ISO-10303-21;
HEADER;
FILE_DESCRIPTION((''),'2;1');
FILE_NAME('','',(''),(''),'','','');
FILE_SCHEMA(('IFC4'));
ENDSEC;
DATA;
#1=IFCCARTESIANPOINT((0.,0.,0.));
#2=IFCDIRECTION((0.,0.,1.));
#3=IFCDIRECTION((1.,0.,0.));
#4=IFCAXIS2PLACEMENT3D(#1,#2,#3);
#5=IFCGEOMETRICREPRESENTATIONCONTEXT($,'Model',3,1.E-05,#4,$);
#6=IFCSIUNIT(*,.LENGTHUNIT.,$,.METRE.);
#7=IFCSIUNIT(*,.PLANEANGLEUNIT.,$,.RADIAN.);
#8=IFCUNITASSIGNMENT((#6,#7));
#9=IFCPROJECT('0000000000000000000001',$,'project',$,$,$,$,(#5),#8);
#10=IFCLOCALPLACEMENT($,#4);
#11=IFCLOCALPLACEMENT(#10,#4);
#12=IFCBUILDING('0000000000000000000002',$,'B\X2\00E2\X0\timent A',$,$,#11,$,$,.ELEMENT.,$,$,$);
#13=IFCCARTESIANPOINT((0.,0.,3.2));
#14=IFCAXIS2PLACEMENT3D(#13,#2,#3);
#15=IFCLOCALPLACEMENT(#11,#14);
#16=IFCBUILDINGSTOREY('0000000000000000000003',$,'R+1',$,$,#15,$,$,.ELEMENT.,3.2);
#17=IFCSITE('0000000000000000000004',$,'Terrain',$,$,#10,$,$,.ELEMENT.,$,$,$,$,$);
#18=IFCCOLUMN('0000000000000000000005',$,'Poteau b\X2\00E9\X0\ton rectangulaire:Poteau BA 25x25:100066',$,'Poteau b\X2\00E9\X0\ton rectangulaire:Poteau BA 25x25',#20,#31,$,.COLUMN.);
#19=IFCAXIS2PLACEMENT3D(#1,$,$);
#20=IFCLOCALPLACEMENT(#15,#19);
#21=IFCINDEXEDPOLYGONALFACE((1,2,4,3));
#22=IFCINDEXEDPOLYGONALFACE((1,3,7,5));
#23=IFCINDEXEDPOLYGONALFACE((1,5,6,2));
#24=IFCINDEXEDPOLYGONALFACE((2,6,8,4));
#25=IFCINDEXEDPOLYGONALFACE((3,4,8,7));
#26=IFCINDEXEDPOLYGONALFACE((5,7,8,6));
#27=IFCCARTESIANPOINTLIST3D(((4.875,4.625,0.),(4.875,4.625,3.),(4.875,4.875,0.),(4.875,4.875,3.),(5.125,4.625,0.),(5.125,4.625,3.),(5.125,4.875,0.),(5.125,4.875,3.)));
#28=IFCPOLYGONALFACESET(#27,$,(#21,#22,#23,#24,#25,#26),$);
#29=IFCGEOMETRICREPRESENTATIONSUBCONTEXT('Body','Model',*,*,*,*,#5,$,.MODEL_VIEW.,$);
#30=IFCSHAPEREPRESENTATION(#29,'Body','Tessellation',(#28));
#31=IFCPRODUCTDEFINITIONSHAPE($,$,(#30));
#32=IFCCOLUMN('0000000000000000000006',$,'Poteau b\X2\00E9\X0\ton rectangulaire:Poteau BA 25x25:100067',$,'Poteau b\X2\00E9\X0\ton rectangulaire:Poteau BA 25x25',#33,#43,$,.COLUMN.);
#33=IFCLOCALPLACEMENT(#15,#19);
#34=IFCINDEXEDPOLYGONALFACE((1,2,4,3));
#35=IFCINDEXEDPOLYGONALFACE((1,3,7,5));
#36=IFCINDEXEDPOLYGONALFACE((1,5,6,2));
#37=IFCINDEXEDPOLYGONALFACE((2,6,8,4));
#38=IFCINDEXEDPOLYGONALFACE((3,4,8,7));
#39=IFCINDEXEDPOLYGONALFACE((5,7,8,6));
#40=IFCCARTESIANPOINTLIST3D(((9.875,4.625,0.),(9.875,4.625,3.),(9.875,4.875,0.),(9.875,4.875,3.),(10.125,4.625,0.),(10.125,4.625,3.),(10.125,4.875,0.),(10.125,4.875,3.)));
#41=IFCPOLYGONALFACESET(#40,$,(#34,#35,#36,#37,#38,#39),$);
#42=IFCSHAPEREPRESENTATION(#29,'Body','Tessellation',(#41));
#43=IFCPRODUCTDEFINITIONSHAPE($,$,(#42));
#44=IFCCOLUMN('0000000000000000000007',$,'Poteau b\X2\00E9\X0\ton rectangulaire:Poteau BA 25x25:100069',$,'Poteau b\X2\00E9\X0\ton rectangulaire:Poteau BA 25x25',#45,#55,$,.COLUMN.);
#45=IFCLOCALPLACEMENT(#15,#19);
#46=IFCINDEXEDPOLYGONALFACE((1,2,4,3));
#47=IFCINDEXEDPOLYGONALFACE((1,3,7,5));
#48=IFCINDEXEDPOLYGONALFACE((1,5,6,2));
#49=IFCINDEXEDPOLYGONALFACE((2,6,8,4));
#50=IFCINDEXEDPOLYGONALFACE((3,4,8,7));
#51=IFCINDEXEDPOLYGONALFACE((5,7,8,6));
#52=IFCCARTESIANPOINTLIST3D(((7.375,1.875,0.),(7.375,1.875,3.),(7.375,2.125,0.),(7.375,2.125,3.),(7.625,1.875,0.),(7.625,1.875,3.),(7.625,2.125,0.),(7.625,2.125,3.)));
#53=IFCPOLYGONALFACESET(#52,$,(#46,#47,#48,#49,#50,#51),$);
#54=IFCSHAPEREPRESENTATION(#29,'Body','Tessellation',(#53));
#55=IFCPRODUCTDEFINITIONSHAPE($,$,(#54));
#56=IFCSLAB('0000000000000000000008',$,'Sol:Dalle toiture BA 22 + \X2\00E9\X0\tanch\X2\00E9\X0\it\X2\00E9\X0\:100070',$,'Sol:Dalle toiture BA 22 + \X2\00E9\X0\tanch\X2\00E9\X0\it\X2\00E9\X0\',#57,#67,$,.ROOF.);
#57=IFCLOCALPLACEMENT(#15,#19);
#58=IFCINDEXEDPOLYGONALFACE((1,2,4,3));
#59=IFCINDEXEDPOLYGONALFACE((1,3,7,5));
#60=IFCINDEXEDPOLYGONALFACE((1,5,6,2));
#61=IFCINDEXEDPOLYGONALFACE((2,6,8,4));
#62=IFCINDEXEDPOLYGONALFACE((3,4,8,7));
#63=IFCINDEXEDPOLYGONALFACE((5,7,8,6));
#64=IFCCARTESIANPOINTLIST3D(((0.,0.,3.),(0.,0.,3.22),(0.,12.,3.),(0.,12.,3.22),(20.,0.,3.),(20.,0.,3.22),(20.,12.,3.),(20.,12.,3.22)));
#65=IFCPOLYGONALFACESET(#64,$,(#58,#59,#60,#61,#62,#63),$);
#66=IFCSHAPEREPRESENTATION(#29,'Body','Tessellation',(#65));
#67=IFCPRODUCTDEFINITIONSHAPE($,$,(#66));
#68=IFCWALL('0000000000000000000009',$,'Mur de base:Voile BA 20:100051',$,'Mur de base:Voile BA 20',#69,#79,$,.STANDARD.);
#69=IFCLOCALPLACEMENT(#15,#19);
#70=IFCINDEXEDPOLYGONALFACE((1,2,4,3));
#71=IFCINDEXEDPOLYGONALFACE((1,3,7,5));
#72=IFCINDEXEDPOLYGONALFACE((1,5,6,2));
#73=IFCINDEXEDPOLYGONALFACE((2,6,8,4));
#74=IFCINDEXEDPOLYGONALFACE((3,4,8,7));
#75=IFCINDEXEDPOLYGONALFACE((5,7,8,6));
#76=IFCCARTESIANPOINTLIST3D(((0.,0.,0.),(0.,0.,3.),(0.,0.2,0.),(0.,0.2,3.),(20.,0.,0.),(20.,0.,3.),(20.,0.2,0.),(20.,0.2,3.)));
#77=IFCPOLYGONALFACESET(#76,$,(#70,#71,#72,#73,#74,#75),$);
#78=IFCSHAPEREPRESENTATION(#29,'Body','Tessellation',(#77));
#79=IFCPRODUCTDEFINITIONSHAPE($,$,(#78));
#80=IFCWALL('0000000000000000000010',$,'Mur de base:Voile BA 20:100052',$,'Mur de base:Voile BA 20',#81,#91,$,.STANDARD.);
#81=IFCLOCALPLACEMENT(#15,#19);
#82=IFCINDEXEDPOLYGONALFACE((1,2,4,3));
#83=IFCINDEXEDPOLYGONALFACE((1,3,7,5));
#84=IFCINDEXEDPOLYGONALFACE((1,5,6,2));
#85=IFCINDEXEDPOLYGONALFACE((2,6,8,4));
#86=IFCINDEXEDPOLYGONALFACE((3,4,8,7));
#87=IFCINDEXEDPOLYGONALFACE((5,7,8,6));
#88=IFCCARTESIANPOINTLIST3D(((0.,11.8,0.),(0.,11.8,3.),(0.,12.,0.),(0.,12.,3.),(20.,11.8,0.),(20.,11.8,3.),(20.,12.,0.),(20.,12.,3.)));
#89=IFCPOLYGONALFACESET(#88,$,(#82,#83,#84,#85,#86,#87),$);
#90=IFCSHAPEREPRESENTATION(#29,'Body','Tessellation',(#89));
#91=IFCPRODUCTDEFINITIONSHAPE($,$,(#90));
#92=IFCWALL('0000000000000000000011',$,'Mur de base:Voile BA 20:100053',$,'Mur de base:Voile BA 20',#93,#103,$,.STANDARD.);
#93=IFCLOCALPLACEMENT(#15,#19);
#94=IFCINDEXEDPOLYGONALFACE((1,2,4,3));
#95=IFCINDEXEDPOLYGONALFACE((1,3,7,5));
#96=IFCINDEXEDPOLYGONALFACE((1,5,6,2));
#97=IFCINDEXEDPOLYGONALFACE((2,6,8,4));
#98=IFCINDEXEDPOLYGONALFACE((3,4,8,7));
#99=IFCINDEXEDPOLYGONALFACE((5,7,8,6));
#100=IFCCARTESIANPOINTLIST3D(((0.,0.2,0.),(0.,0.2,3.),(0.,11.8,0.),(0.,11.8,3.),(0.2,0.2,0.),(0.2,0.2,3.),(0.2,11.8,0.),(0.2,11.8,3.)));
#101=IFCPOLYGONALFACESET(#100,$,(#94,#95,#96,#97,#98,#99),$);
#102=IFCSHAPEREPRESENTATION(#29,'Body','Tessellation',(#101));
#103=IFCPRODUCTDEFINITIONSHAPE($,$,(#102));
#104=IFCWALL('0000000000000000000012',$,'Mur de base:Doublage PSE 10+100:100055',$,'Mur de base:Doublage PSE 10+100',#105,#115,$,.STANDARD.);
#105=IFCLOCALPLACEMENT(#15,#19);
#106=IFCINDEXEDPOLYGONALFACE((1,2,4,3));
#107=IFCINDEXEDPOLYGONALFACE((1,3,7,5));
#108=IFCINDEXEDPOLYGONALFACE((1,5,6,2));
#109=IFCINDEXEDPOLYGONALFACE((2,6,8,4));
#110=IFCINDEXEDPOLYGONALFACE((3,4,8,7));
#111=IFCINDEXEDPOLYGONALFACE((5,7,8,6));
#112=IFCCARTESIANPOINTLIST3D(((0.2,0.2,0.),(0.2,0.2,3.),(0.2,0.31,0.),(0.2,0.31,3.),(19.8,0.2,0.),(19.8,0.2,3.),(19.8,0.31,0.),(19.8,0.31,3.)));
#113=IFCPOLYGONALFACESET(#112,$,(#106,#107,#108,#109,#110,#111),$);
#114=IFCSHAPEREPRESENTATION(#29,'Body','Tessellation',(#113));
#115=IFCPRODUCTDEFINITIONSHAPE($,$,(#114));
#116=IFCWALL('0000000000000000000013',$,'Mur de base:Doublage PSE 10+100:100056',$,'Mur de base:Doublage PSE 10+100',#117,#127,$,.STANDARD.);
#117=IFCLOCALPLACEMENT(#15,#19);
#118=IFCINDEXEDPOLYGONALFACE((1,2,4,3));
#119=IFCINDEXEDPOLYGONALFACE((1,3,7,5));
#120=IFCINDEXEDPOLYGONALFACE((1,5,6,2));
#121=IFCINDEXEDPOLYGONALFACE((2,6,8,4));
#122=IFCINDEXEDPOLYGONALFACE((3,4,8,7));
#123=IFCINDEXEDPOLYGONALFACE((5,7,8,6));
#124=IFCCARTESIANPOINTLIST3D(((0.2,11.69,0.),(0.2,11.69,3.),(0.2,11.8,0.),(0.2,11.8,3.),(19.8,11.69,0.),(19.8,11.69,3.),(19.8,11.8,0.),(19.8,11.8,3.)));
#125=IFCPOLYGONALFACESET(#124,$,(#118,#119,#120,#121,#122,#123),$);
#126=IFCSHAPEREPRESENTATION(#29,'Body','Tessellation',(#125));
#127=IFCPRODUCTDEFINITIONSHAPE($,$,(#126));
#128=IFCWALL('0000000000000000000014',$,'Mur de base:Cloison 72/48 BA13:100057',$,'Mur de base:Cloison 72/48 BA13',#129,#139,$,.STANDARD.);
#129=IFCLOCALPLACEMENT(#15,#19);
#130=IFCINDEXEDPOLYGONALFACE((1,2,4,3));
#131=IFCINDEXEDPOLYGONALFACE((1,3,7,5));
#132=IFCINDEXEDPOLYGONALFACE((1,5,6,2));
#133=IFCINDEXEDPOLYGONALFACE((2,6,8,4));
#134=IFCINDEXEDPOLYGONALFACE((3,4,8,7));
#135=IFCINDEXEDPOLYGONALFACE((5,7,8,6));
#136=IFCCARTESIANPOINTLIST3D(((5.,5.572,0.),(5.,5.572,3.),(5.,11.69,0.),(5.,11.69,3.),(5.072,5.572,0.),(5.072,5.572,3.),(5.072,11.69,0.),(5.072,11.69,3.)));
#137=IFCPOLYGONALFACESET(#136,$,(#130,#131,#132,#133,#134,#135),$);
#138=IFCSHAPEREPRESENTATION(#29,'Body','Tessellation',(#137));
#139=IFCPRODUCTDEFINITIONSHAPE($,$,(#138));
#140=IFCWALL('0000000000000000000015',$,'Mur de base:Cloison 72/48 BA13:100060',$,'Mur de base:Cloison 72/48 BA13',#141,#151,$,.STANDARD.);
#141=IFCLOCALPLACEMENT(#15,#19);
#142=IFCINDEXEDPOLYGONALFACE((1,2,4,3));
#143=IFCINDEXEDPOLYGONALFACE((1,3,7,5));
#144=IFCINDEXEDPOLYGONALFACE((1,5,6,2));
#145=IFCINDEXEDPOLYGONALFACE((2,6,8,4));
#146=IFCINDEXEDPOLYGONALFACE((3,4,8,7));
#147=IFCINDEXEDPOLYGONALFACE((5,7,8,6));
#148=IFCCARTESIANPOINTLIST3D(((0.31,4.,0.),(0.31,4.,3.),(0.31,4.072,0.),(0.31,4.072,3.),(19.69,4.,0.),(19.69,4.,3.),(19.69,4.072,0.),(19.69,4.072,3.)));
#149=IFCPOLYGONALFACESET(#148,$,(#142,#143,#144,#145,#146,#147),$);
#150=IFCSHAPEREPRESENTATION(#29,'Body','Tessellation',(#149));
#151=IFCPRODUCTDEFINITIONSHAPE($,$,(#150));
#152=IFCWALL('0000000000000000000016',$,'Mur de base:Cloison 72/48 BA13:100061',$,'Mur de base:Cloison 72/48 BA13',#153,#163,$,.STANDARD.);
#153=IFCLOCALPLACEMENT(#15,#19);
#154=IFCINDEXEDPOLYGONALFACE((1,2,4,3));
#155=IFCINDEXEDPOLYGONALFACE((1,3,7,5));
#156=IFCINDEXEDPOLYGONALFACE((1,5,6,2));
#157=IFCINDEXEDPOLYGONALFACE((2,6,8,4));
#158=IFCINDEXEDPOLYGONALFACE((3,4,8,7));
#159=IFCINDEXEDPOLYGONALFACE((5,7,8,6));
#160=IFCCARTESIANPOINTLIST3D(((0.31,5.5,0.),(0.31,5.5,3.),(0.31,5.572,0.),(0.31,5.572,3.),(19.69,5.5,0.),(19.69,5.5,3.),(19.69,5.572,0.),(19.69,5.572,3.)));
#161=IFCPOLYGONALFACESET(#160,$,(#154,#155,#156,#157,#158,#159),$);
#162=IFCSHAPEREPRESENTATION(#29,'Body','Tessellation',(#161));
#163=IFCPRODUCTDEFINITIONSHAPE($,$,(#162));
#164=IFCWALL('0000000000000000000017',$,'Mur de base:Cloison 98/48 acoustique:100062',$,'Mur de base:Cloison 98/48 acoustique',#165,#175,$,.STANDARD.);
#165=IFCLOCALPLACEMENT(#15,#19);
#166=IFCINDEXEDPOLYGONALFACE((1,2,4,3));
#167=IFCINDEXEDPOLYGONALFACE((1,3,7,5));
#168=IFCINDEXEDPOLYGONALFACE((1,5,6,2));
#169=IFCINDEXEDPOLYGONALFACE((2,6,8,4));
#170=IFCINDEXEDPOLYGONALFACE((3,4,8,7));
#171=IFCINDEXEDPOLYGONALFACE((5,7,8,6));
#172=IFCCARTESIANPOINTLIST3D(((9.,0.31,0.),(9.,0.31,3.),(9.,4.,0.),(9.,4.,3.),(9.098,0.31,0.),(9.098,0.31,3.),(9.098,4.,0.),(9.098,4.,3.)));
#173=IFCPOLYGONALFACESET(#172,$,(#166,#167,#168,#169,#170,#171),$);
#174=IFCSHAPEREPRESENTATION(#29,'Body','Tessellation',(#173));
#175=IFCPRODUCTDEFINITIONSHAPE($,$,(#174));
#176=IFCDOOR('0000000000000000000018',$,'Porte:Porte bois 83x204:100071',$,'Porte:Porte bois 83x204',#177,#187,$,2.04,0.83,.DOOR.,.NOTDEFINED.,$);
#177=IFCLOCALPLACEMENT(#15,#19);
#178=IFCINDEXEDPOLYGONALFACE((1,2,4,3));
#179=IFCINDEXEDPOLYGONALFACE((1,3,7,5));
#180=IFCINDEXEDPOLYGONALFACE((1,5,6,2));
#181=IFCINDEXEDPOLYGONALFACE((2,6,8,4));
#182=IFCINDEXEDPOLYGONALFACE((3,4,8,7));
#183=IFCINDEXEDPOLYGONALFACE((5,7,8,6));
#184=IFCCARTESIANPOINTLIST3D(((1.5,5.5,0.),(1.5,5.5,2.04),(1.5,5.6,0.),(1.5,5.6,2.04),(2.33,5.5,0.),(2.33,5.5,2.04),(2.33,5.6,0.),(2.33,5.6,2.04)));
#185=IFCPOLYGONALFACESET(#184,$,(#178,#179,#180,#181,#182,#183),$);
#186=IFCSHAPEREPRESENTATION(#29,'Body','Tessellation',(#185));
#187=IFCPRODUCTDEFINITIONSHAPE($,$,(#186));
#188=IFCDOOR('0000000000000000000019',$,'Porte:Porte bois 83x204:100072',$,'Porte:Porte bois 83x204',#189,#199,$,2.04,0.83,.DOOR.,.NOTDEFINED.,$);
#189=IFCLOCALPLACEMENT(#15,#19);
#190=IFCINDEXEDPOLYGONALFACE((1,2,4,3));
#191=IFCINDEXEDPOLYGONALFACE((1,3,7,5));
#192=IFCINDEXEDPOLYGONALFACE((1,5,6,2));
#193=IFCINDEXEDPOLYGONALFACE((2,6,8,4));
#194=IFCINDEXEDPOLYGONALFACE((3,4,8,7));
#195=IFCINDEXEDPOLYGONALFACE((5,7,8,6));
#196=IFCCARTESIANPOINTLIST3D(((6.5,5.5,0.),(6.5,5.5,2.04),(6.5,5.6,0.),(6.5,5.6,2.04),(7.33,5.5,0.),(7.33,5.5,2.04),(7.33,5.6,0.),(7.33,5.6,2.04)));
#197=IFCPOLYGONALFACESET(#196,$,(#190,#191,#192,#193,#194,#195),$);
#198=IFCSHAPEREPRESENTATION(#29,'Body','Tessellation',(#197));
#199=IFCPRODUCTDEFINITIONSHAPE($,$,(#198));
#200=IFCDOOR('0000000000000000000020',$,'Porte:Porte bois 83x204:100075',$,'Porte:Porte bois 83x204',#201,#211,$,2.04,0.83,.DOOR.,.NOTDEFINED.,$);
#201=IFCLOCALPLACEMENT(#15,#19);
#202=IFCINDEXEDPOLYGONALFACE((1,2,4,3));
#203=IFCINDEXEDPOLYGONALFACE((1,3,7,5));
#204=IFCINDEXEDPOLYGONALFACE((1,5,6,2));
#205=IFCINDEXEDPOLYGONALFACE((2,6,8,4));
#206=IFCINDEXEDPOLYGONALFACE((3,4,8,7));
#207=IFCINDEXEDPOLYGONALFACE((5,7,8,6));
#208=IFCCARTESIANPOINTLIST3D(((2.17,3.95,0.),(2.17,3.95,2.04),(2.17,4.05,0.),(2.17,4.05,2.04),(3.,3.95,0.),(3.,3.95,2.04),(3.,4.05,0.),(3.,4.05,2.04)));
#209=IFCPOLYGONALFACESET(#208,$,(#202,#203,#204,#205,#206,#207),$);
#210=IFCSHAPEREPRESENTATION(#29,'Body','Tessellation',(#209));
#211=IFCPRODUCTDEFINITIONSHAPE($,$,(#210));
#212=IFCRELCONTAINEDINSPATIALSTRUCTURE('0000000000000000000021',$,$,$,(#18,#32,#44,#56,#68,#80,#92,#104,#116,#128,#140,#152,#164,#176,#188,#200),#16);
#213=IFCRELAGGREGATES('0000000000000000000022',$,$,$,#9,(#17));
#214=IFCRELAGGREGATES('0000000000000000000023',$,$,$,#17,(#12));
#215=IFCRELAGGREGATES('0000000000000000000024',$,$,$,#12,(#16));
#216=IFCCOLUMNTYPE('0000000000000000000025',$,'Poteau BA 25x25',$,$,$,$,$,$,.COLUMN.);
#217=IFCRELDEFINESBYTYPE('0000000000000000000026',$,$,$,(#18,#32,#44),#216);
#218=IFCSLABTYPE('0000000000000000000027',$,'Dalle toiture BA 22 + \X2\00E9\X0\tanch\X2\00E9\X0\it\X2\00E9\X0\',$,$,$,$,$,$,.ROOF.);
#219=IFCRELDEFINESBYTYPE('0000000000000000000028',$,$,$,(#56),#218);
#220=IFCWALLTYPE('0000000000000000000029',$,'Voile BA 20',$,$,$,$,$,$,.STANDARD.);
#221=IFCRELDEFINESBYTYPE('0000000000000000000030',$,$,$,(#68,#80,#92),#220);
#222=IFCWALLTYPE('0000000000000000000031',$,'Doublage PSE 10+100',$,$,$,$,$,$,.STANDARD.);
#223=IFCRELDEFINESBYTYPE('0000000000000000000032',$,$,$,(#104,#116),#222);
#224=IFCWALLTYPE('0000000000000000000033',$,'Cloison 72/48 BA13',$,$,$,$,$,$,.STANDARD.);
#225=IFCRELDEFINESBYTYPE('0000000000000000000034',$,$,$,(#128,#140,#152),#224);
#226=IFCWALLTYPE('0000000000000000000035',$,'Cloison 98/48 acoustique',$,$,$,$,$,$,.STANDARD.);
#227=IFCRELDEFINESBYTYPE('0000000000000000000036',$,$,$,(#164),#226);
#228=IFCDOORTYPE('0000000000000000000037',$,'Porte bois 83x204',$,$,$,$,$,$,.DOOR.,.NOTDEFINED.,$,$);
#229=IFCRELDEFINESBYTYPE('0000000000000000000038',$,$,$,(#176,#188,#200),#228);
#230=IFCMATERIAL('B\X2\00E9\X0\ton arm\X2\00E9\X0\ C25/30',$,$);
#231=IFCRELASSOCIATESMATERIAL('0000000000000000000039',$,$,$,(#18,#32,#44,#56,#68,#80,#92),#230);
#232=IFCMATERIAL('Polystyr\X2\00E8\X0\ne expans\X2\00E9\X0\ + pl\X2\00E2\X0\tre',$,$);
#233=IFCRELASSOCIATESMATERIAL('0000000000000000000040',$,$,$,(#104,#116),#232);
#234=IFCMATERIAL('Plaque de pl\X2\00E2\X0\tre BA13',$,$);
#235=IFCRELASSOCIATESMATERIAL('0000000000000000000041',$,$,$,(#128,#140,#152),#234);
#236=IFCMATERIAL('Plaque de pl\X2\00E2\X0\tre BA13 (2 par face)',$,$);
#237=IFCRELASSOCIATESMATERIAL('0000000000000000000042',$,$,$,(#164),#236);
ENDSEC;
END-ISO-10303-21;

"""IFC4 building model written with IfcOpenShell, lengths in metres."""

from ifc_helpers import new_model, si_unit, frame, frame_2d, origin_with_axes, place, context, subcontext, project, spatial, rectangle, extrude, material, type_object, element, save


model = new_model("IFC4")

# Units and contexts
model_context = context("Model", 3, precision=1e-05, world=origin_with_axes())
body_context = subcontext(model_context, "Body", "Model", "MODEL_VIEW")
ifc_project = project(units=[si_unit("LENGTHUNIT", "METRE"), si_unit("PLANEANGLEUNIT", "RADIAN")], contexts=[model_context])

# Site, building, storey
site_placement = place(None, origin_with_axes())
site = spatial("IfcSite", under=ifc_project, at=site_placement, Name="Terrain", CompositionType="ELEMENT")
building_placement = place(site_placement, origin_with_axes())
building = spatial("IfcBuilding", under=site, at=building_placement, Name="Bâtiment A", CompositionType="ELEMENT")
storey_placement = place(building_placement, frame((0.0, 0.0, 3.2), z_axis=(0.0, 0.0, 1.0), x_axis=(1.0, 0.0, 0.0)))
storey = spatial("IfcBuildingStorey", under=building, at=storey_placement, Name="R+1", CompositionType="ELEMENT", Elevation=3.2)

# Columns
ifc_material_1 = material(Name="Béton armé C25/30")
column_type = type_object("IfcColumnType", Name="Poteau BA 25x25", PredefinedType="COLUMN")
for number, where, z_axis, x_axis, name in (
    (1, (4.875, 4.625, 0.0), (0.0, 0.0, 1.0), (1.0, 0.0, 0.0), "Poteau béton rectangulaire:Poteau BA 25x25:100066"),
    (2, (9.875, 4.625, 0.0), (0.0, 0.0, 1.0), (1.0, 0.0, 0.0), "Poteau béton rectangulaire:Poteau BA 25x25:100067"),
    (3, (7.375, 1.875, 0.0), (0.0, 0.0, 1.0), (1.0, 0.0, 0.0), "Poteau béton rectangulaire:Poteau BA 25x25:100069"),
):
    element("IfcColumn", number, at=place(storey_placement, frame(where, z_axis=z_axis, x_axis=x_axis)), inside=storey, type_object=column_type, material=ifc_material_1, Name=name, ObjectType="Poteau béton rectangulaire:Poteau BA 25x25", PredefinedType="COLUMN", context=body_context, shape_type="SweptSolid", body=[
        extrude(rectangle(XDim=0.25, YDim=0.25, at=frame_2d((0.125, 0.125))), origin_with_axes(), (0.0, 0.0, 1.0), 3.0),
    ])

# Slab
slab_type = type_object("IfcSlabType", Name="Dalle toiture BA 22 + étanchéité", PredefinedType="ROOF")
slab_placement = place(storey_placement, frame((0.0, 0.0, 3.0), z_axis=(0.0, 0.0, 1.0), x_axis=(1.0, 0.0, 0.0)))
element("IfcSlab", 4, at=slab_placement, inside=storey, type_object=slab_type, material=ifc_material_1, Name="Sol:Dalle toiture BA 22 + étanchéité:100070", ObjectType="Sol:Dalle toiture BA 22 + étanchéité", PredefinedType="ROOF", context=body_context, shape_type="SweptSolid", body=[
    extrude(rectangle(XDim=20.0, YDim=12.0, at=frame_2d((10.0, 6.0))), origin_with_axes(), (0.0, 0.0, 1.0), 0.22),
])

# Walls
wall_type_1 = type_object("IfcWallType", Name="Voile BA 20", PredefinedType="STANDARD")
for number, where, z_axis, x_axis, name in (
    (5, (0.0, 0.0, 0.0), (0.0, 0.0, 1.0), (1.0, 0.0, 0.0), "Mur de base:Voile BA 20:100051"),
    (6, (0.0, 11.8, 0.0), (0.0, 0.0, 1.0), (1.0, 0.0, 0.0), "Mur de base:Voile BA 20:100052"),
):
    element("IfcWall", number, at=place(storey_placement, frame(where, z_axis=z_axis, x_axis=x_axis)), inside=storey, type_object=wall_type_1, material=ifc_material_1, Name=name, ObjectType="Mur de base:Voile BA 20", PredefinedType="STANDARD", context=body_context, shape_type="SweptSolid", body=[
        extrude(rectangle(XDim=20.0, YDim=0.2, at=frame_2d((10.0, 0.1))), origin_with_axes(), (0.0, 0.0, 1.0), 3.0),
    ])
wall_1_placement = place(storey_placement, frame((0.2, 0.2, 0.0), z_axis=(0.0, 0.0, 1.0), x_axis=(0.0, 1.0, 0.0)))
element("IfcWall", 7, at=wall_1_placement, inside=storey, type_object=wall_type_1, material=ifc_material_1, Name="Mur de base:Voile BA 20:100053", ObjectType="Mur de base:Voile BA 20", PredefinedType="STANDARD", context=body_context, shape_type="SweptSolid", body=[
    extrude(rectangle(XDim=11.6, YDim=0.2, at=frame_2d((5.8, 0.1))), origin_with_axes(), (0.0, 0.0, 1.0), 3.0),
])
ifc_material_2 = material(Name="Polystyrène expansé + plâtre")
wall_type_2 = type_object("IfcWallType", Name="Doublage PSE 10+100", PredefinedType="STANDARD")
for number, where, z_axis, x_axis, name in (
    (8, (0.2, 0.2, 0.0), (0.0, 0.0, 1.0), (1.0, 0.0, 0.0), "Mur de base:Doublage PSE 10+100:100055"),
    (9, (0.2, 11.69, 0.0), (0.0, 0.0, 1.0), (1.0, 0.0, 0.0), "Mur de base:Doublage PSE 10+100:100056"),
):
    element("IfcWall", number, at=place(storey_placement, frame(where, z_axis=z_axis, x_axis=x_axis)), inside=storey, type_object=wall_type_2, material=ifc_material_2, Name=name, ObjectType="Mur de base:Doublage PSE 10+100", PredefinedType="STANDARD", context=body_context, shape_type="SweptSolid", body=[
        extrude(rectangle(XDim=19.6, YDim=0.11, at=frame_2d((9.8, 0.055))), origin_with_axes(), (0.0, 0.0, 1.0), 3.0),
    ])
ifc_material_3 = material(Name="Plaque de plâtre BA13")
wall_type_3 = type_object("IfcWallType", Name="Cloison 72/48 BA13", PredefinedType="STANDARD")
wall_2_placement = place(storey_placement, frame((5.072, 5.572, 0.0), z_axis=(0.0, 0.0, 1.0), x_axis=(0.0, 1.0, 0.0)))
element("IfcWall", 10, at=wall_2_placement, inside=storey, type_object=wall_type_3, material=ifc_material_3, Name="Mur de base:Cloison 72/48 BA13:100057", ObjectType="Mur de base:Cloison 72/48 BA13", PredefinedType="STANDARD", context=body_context, shape_type="SweptSolid", body=[
    extrude(rectangle(XDim=6.118, YDim=0.072, at=frame_2d((3.059, 0.036))), origin_with_axes(), (0.0, 0.0, 1.0), 3.0),
])
for number, where, z_axis, x_axis, name in (
    (11, (0.31, 4.0, 0.0), (0.0, 0.0, 1.0), (1.0, 0.0, 0.0), "Mur de base:Cloison 72/48 BA13:100060"),
    (12, (0.31, 5.5, 0.0), (0.0, 0.0, 1.0), (1.0, 0.0, 0.0), "Mur de base:Cloison 72/48 BA13:100061"),
):
    element("IfcWall", number, at=place(storey_placement, frame(where, z_axis=z_axis, x_axis=x_axis)), inside=storey, type_object=wall_type_3, material=ifc_material_3, Name=name, ObjectType="Mur de base:Cloison 72/48 BA13", PredefinedType="STANDARD", context=body_context, shape_type="SweptSolid", body=[
        extrude(rectangle(XDim=19.38, YDim=0.072, at=frame_2d((9.69, 0.036))), origin_with_axes(), (0.0, 0.0, 1.0), 3.0),
    ])
ifc_material_4 = material(Name="Plaque de plâtre BA13 (2 par face)")
wall_type_4 = type_object("IfcWallType", Name="Cloison 98/48 acoustique", PredefinedType="STANDARD")
wall_3_placement = place(storey_placement, frame((9.098, 0.31, 0.0), z_axis=(0.0, 0.0, 1.0), x_axis=(0.0, 1.0, 0.0)))
element("IfcWall", 13, at=wall_3_placement, inside=storey, type_object=wall_type_4, material=ifc_material_4, Name="Mur de base:Cloison 98/48 acoustique:100062", ObjectType="Mur de base:Cloison 98/48 acoustique", PredefinedType="STANDARD", context=body_context, shape_type="SweptSolid", body=[
    extrude(rectangle(XDim=3.69, YDim=0.098, at=frame_2d((1.845, 0.049))), origin_with_axes(), (0.0, 0.0, 1.0), 3.0),
])

# Doors
door_type_1 = type_object("IfcDoorType", Name="Porte bois 83x204", OperationType="NOTDEFINED", PredefinedType="DOOR")
for number, where, z_axis, x_axis, name in (
    (14, (1.5, 5.5, 0.0), (0.0, 0.0, 1.0), (1.0, 0.0, 0.0), "Porte:Porte bois 83x204:100071"),
    (15, (6.5, 5.5, 0.0), (0.0, 0.0, 1.0), (1.0, 0.0, 0.0), "Porte:Porte bois 83x204:100072"),
    (16, (2.17, 3.95, 0.0), (0.0, 0.0, 1.0), (1.0, 0.0, 0.0), "Porte:Porte bois 83x204:100075"),
):
    element("IfcDoor", number, at=place(storey_placement, frame(where, z_axis=z_axis, x_axis=x_axis)), inside=storey, type_object=door_type_1, Name=name, ObjectType="Porte:Porte bois 83x204", OperationType="NOTDEFINED", OverallHeight=2.04, OverallWidth=0.83, PredefinedType="DOOR", context=body_context, shape_type="SweptSolid", body=[
        extrude(rectangle(XDim=0.83, YDim=0.1, at=frame_2d((0.415, 0.05))), origin_with_axes(), (0.0, 0.0, 1.0), 2.04),
    ])

save(model, "model.ifc")
